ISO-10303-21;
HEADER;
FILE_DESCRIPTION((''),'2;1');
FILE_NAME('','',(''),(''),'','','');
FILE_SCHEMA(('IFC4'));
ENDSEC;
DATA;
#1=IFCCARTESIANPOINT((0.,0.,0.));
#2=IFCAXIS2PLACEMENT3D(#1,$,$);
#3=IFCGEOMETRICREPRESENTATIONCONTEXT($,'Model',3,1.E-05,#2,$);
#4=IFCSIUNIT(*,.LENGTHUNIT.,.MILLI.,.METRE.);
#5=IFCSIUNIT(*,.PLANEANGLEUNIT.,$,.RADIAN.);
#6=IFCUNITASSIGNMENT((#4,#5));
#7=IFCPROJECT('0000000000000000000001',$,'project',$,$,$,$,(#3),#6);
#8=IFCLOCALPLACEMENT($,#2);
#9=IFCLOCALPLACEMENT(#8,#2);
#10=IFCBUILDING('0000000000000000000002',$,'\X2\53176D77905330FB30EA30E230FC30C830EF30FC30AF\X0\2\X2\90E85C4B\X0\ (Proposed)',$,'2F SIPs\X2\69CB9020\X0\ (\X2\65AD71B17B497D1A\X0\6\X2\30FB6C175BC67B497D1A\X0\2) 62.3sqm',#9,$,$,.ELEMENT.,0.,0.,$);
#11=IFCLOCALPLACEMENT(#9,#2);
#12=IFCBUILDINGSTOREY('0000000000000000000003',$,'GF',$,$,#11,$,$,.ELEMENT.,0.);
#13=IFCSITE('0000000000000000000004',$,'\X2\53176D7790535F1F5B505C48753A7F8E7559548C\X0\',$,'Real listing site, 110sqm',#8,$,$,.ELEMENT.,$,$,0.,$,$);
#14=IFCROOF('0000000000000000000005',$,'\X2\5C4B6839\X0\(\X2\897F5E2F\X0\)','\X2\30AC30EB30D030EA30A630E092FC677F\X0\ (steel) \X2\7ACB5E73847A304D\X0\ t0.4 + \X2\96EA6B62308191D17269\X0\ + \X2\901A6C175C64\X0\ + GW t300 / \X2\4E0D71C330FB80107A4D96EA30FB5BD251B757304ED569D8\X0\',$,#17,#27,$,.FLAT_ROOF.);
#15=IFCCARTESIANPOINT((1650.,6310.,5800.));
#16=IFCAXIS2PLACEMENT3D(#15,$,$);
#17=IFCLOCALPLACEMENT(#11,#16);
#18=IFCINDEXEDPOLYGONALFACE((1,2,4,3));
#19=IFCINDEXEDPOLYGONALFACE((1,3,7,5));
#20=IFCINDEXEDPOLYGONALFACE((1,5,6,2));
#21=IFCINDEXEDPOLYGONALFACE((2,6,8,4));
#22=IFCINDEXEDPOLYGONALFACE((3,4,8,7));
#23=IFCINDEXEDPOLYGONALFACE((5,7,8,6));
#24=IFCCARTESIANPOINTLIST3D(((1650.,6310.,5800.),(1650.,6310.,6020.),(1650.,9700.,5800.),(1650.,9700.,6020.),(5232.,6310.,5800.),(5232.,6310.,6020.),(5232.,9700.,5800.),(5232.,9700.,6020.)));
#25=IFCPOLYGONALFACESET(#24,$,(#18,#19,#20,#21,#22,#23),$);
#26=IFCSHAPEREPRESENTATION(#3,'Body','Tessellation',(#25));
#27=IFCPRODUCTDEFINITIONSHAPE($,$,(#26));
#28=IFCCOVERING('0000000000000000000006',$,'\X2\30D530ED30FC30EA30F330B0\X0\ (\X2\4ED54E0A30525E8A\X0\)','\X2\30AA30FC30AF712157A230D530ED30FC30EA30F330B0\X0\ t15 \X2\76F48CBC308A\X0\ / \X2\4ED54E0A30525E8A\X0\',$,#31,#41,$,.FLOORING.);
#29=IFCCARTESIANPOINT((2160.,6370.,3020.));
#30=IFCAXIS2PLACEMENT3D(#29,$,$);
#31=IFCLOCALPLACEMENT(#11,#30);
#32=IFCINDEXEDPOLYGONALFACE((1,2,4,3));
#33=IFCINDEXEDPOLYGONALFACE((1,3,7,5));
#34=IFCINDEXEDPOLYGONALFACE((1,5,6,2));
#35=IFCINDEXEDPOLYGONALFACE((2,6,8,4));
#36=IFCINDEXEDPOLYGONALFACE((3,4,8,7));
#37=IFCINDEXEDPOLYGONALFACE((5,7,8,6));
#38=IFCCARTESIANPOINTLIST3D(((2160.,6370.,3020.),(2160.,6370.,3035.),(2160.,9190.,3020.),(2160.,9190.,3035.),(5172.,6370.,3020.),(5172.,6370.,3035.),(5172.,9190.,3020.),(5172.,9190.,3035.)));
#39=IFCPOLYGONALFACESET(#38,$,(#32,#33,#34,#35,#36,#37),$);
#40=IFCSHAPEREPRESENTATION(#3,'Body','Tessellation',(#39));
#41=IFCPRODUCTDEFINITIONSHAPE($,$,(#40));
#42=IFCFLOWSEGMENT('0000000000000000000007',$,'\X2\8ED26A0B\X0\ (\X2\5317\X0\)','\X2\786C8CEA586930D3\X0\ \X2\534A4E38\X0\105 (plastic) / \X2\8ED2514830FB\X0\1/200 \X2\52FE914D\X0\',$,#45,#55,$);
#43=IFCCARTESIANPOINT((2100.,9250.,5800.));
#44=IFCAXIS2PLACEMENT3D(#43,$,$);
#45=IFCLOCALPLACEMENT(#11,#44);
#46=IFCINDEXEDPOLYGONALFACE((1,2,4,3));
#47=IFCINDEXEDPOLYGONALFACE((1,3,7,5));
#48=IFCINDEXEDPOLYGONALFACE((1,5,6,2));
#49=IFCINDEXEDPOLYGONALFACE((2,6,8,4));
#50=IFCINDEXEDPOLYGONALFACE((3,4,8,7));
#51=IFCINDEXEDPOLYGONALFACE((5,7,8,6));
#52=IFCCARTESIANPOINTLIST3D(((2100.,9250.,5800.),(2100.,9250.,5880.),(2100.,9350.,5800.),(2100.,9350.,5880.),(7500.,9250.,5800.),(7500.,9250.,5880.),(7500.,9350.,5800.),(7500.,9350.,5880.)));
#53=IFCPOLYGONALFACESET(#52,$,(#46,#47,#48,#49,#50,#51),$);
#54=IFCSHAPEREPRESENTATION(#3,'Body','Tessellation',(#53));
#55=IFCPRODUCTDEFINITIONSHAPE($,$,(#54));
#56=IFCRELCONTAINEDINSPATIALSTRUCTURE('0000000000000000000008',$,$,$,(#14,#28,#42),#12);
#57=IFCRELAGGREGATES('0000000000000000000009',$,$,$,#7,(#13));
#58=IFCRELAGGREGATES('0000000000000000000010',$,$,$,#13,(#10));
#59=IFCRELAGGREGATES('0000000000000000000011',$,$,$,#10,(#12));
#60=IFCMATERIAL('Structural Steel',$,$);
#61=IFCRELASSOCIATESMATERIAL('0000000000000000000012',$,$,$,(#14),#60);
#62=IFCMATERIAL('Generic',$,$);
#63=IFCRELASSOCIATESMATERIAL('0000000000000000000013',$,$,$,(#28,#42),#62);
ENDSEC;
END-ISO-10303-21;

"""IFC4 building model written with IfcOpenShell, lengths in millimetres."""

from ifc_helpers import new_model, si_unit, frame, frame_2d, origin, place, context, project, spatial, rectangle, extrude, material, element, save


model = new_model("IFC4")

# Units and contexts
model_context = context("Model", 3, precision=1e-05, world=origin())
ifc_project = project(units=[si_unit("LENGTHUNIT", "METRE", prefix="MILLI"), si_unit("PLANEANGLEUNIT", "RADIAN")], contexts=[model_context])

# Site, building, storey
site_placement = place(None, origin())
site = spatial("IfcSite", under=ifc_project, at=site_placement, Name="北海道弟子屈町美留和", ObjectType="Real listing site, 110sqm", CompositionType="ELEMENT", RefElevation=0.0)
building_placement = place(site_placement, origin())
building = spatial("IfcBuilding", under=site, at=building_placement, Name="北海道・リモートワーク2部屋 (Proposed)", ObjectType="2F SIPs構造 (断熱等級6・気密等級2) 62.3sqm", CompositionType="ELEMENT", ElevationOfRefHeight=0.0, ElevationOfTerrain=0.0)
storey_placement = place(building_placement, origin())
storey = spatial("IfcBuildingStorey", under=building, at=storey_placement, Name="GF", CompositionType="ELEMENT", Elevation=0.0)

# Roof
ifc_material_1 = material(Name="Structural Steel")
for number, where, name in (
    (1, (1650.0, 6310.0, 5800.0), "屋根(西帯)"),
):
    element("IfcRoof", number, at=place(storey_placement, frame(where)), inside=storey, material=ifc_material_1, Name=name, Description="ガルバリウム鋼板 (steel) 立平葺き t0.4 + 雪止め金物 + 通気層 + GW t300 / 不燃・耐積雪・寒冷地仕様", PredefinedType="FLAT_ROOF", context=model_context, shape_type="SweptSolid", body=[
        extrude(rectangle(XDim=3582.0, YDim=3390.0, at=frame_2d((1791.0, 1695.0))), frame((1650.0, 6310.0, 5800.0)), (0.0, 0.0, 1.0), 220.0),
    ])

# Covering
ifc_material_2 = material(Name="Generic")
covering_placement = place(storey_placement, frame((2160.0, 6370.0, 3020.0)))
element("IfcCovering", 2, at=covering_placement, inside=storey, material=ifc_material_2, Name="フローリング (仕上げ床)", Description="オーク無垢フローリング t15 直貼り / 仕上げ床", PredefinedType="FLOORING", context=model_context, shape_type="SweptSolid", body=[
    extrude(rectangle(XDim=3012.0, YDim=2820.0, at=frame_2d((1506.0, 1410.0))), frame((2160.0, 6370.0, 3020.0)), (0.0, 0.0, 1.0), 15.0),
])

# Flow segment
flow_segment_placement = place(storey_placement, frame((2100.0, 9250.0, 5800.0)))
element("IfcFlowSegment", 3, at=flow_segment_placement, inside=storey, material=ifc_material_2, Name="軒樋 (北)", Description="硬質塩ビ 半丸105 (plastic) / 軒先・1/200 勾配", context=model_context, shape_type="SweptSolid", body=[
    extrude(rectangle(XDim=5400.0, YDim=100.0, at=frame_2d((2700.0, 50.0))), frame((2100.0, 9250.0, 5800.0)), (0.0, 0.0, 1.0), 80.0),
])

save(model, "model.ifc")
